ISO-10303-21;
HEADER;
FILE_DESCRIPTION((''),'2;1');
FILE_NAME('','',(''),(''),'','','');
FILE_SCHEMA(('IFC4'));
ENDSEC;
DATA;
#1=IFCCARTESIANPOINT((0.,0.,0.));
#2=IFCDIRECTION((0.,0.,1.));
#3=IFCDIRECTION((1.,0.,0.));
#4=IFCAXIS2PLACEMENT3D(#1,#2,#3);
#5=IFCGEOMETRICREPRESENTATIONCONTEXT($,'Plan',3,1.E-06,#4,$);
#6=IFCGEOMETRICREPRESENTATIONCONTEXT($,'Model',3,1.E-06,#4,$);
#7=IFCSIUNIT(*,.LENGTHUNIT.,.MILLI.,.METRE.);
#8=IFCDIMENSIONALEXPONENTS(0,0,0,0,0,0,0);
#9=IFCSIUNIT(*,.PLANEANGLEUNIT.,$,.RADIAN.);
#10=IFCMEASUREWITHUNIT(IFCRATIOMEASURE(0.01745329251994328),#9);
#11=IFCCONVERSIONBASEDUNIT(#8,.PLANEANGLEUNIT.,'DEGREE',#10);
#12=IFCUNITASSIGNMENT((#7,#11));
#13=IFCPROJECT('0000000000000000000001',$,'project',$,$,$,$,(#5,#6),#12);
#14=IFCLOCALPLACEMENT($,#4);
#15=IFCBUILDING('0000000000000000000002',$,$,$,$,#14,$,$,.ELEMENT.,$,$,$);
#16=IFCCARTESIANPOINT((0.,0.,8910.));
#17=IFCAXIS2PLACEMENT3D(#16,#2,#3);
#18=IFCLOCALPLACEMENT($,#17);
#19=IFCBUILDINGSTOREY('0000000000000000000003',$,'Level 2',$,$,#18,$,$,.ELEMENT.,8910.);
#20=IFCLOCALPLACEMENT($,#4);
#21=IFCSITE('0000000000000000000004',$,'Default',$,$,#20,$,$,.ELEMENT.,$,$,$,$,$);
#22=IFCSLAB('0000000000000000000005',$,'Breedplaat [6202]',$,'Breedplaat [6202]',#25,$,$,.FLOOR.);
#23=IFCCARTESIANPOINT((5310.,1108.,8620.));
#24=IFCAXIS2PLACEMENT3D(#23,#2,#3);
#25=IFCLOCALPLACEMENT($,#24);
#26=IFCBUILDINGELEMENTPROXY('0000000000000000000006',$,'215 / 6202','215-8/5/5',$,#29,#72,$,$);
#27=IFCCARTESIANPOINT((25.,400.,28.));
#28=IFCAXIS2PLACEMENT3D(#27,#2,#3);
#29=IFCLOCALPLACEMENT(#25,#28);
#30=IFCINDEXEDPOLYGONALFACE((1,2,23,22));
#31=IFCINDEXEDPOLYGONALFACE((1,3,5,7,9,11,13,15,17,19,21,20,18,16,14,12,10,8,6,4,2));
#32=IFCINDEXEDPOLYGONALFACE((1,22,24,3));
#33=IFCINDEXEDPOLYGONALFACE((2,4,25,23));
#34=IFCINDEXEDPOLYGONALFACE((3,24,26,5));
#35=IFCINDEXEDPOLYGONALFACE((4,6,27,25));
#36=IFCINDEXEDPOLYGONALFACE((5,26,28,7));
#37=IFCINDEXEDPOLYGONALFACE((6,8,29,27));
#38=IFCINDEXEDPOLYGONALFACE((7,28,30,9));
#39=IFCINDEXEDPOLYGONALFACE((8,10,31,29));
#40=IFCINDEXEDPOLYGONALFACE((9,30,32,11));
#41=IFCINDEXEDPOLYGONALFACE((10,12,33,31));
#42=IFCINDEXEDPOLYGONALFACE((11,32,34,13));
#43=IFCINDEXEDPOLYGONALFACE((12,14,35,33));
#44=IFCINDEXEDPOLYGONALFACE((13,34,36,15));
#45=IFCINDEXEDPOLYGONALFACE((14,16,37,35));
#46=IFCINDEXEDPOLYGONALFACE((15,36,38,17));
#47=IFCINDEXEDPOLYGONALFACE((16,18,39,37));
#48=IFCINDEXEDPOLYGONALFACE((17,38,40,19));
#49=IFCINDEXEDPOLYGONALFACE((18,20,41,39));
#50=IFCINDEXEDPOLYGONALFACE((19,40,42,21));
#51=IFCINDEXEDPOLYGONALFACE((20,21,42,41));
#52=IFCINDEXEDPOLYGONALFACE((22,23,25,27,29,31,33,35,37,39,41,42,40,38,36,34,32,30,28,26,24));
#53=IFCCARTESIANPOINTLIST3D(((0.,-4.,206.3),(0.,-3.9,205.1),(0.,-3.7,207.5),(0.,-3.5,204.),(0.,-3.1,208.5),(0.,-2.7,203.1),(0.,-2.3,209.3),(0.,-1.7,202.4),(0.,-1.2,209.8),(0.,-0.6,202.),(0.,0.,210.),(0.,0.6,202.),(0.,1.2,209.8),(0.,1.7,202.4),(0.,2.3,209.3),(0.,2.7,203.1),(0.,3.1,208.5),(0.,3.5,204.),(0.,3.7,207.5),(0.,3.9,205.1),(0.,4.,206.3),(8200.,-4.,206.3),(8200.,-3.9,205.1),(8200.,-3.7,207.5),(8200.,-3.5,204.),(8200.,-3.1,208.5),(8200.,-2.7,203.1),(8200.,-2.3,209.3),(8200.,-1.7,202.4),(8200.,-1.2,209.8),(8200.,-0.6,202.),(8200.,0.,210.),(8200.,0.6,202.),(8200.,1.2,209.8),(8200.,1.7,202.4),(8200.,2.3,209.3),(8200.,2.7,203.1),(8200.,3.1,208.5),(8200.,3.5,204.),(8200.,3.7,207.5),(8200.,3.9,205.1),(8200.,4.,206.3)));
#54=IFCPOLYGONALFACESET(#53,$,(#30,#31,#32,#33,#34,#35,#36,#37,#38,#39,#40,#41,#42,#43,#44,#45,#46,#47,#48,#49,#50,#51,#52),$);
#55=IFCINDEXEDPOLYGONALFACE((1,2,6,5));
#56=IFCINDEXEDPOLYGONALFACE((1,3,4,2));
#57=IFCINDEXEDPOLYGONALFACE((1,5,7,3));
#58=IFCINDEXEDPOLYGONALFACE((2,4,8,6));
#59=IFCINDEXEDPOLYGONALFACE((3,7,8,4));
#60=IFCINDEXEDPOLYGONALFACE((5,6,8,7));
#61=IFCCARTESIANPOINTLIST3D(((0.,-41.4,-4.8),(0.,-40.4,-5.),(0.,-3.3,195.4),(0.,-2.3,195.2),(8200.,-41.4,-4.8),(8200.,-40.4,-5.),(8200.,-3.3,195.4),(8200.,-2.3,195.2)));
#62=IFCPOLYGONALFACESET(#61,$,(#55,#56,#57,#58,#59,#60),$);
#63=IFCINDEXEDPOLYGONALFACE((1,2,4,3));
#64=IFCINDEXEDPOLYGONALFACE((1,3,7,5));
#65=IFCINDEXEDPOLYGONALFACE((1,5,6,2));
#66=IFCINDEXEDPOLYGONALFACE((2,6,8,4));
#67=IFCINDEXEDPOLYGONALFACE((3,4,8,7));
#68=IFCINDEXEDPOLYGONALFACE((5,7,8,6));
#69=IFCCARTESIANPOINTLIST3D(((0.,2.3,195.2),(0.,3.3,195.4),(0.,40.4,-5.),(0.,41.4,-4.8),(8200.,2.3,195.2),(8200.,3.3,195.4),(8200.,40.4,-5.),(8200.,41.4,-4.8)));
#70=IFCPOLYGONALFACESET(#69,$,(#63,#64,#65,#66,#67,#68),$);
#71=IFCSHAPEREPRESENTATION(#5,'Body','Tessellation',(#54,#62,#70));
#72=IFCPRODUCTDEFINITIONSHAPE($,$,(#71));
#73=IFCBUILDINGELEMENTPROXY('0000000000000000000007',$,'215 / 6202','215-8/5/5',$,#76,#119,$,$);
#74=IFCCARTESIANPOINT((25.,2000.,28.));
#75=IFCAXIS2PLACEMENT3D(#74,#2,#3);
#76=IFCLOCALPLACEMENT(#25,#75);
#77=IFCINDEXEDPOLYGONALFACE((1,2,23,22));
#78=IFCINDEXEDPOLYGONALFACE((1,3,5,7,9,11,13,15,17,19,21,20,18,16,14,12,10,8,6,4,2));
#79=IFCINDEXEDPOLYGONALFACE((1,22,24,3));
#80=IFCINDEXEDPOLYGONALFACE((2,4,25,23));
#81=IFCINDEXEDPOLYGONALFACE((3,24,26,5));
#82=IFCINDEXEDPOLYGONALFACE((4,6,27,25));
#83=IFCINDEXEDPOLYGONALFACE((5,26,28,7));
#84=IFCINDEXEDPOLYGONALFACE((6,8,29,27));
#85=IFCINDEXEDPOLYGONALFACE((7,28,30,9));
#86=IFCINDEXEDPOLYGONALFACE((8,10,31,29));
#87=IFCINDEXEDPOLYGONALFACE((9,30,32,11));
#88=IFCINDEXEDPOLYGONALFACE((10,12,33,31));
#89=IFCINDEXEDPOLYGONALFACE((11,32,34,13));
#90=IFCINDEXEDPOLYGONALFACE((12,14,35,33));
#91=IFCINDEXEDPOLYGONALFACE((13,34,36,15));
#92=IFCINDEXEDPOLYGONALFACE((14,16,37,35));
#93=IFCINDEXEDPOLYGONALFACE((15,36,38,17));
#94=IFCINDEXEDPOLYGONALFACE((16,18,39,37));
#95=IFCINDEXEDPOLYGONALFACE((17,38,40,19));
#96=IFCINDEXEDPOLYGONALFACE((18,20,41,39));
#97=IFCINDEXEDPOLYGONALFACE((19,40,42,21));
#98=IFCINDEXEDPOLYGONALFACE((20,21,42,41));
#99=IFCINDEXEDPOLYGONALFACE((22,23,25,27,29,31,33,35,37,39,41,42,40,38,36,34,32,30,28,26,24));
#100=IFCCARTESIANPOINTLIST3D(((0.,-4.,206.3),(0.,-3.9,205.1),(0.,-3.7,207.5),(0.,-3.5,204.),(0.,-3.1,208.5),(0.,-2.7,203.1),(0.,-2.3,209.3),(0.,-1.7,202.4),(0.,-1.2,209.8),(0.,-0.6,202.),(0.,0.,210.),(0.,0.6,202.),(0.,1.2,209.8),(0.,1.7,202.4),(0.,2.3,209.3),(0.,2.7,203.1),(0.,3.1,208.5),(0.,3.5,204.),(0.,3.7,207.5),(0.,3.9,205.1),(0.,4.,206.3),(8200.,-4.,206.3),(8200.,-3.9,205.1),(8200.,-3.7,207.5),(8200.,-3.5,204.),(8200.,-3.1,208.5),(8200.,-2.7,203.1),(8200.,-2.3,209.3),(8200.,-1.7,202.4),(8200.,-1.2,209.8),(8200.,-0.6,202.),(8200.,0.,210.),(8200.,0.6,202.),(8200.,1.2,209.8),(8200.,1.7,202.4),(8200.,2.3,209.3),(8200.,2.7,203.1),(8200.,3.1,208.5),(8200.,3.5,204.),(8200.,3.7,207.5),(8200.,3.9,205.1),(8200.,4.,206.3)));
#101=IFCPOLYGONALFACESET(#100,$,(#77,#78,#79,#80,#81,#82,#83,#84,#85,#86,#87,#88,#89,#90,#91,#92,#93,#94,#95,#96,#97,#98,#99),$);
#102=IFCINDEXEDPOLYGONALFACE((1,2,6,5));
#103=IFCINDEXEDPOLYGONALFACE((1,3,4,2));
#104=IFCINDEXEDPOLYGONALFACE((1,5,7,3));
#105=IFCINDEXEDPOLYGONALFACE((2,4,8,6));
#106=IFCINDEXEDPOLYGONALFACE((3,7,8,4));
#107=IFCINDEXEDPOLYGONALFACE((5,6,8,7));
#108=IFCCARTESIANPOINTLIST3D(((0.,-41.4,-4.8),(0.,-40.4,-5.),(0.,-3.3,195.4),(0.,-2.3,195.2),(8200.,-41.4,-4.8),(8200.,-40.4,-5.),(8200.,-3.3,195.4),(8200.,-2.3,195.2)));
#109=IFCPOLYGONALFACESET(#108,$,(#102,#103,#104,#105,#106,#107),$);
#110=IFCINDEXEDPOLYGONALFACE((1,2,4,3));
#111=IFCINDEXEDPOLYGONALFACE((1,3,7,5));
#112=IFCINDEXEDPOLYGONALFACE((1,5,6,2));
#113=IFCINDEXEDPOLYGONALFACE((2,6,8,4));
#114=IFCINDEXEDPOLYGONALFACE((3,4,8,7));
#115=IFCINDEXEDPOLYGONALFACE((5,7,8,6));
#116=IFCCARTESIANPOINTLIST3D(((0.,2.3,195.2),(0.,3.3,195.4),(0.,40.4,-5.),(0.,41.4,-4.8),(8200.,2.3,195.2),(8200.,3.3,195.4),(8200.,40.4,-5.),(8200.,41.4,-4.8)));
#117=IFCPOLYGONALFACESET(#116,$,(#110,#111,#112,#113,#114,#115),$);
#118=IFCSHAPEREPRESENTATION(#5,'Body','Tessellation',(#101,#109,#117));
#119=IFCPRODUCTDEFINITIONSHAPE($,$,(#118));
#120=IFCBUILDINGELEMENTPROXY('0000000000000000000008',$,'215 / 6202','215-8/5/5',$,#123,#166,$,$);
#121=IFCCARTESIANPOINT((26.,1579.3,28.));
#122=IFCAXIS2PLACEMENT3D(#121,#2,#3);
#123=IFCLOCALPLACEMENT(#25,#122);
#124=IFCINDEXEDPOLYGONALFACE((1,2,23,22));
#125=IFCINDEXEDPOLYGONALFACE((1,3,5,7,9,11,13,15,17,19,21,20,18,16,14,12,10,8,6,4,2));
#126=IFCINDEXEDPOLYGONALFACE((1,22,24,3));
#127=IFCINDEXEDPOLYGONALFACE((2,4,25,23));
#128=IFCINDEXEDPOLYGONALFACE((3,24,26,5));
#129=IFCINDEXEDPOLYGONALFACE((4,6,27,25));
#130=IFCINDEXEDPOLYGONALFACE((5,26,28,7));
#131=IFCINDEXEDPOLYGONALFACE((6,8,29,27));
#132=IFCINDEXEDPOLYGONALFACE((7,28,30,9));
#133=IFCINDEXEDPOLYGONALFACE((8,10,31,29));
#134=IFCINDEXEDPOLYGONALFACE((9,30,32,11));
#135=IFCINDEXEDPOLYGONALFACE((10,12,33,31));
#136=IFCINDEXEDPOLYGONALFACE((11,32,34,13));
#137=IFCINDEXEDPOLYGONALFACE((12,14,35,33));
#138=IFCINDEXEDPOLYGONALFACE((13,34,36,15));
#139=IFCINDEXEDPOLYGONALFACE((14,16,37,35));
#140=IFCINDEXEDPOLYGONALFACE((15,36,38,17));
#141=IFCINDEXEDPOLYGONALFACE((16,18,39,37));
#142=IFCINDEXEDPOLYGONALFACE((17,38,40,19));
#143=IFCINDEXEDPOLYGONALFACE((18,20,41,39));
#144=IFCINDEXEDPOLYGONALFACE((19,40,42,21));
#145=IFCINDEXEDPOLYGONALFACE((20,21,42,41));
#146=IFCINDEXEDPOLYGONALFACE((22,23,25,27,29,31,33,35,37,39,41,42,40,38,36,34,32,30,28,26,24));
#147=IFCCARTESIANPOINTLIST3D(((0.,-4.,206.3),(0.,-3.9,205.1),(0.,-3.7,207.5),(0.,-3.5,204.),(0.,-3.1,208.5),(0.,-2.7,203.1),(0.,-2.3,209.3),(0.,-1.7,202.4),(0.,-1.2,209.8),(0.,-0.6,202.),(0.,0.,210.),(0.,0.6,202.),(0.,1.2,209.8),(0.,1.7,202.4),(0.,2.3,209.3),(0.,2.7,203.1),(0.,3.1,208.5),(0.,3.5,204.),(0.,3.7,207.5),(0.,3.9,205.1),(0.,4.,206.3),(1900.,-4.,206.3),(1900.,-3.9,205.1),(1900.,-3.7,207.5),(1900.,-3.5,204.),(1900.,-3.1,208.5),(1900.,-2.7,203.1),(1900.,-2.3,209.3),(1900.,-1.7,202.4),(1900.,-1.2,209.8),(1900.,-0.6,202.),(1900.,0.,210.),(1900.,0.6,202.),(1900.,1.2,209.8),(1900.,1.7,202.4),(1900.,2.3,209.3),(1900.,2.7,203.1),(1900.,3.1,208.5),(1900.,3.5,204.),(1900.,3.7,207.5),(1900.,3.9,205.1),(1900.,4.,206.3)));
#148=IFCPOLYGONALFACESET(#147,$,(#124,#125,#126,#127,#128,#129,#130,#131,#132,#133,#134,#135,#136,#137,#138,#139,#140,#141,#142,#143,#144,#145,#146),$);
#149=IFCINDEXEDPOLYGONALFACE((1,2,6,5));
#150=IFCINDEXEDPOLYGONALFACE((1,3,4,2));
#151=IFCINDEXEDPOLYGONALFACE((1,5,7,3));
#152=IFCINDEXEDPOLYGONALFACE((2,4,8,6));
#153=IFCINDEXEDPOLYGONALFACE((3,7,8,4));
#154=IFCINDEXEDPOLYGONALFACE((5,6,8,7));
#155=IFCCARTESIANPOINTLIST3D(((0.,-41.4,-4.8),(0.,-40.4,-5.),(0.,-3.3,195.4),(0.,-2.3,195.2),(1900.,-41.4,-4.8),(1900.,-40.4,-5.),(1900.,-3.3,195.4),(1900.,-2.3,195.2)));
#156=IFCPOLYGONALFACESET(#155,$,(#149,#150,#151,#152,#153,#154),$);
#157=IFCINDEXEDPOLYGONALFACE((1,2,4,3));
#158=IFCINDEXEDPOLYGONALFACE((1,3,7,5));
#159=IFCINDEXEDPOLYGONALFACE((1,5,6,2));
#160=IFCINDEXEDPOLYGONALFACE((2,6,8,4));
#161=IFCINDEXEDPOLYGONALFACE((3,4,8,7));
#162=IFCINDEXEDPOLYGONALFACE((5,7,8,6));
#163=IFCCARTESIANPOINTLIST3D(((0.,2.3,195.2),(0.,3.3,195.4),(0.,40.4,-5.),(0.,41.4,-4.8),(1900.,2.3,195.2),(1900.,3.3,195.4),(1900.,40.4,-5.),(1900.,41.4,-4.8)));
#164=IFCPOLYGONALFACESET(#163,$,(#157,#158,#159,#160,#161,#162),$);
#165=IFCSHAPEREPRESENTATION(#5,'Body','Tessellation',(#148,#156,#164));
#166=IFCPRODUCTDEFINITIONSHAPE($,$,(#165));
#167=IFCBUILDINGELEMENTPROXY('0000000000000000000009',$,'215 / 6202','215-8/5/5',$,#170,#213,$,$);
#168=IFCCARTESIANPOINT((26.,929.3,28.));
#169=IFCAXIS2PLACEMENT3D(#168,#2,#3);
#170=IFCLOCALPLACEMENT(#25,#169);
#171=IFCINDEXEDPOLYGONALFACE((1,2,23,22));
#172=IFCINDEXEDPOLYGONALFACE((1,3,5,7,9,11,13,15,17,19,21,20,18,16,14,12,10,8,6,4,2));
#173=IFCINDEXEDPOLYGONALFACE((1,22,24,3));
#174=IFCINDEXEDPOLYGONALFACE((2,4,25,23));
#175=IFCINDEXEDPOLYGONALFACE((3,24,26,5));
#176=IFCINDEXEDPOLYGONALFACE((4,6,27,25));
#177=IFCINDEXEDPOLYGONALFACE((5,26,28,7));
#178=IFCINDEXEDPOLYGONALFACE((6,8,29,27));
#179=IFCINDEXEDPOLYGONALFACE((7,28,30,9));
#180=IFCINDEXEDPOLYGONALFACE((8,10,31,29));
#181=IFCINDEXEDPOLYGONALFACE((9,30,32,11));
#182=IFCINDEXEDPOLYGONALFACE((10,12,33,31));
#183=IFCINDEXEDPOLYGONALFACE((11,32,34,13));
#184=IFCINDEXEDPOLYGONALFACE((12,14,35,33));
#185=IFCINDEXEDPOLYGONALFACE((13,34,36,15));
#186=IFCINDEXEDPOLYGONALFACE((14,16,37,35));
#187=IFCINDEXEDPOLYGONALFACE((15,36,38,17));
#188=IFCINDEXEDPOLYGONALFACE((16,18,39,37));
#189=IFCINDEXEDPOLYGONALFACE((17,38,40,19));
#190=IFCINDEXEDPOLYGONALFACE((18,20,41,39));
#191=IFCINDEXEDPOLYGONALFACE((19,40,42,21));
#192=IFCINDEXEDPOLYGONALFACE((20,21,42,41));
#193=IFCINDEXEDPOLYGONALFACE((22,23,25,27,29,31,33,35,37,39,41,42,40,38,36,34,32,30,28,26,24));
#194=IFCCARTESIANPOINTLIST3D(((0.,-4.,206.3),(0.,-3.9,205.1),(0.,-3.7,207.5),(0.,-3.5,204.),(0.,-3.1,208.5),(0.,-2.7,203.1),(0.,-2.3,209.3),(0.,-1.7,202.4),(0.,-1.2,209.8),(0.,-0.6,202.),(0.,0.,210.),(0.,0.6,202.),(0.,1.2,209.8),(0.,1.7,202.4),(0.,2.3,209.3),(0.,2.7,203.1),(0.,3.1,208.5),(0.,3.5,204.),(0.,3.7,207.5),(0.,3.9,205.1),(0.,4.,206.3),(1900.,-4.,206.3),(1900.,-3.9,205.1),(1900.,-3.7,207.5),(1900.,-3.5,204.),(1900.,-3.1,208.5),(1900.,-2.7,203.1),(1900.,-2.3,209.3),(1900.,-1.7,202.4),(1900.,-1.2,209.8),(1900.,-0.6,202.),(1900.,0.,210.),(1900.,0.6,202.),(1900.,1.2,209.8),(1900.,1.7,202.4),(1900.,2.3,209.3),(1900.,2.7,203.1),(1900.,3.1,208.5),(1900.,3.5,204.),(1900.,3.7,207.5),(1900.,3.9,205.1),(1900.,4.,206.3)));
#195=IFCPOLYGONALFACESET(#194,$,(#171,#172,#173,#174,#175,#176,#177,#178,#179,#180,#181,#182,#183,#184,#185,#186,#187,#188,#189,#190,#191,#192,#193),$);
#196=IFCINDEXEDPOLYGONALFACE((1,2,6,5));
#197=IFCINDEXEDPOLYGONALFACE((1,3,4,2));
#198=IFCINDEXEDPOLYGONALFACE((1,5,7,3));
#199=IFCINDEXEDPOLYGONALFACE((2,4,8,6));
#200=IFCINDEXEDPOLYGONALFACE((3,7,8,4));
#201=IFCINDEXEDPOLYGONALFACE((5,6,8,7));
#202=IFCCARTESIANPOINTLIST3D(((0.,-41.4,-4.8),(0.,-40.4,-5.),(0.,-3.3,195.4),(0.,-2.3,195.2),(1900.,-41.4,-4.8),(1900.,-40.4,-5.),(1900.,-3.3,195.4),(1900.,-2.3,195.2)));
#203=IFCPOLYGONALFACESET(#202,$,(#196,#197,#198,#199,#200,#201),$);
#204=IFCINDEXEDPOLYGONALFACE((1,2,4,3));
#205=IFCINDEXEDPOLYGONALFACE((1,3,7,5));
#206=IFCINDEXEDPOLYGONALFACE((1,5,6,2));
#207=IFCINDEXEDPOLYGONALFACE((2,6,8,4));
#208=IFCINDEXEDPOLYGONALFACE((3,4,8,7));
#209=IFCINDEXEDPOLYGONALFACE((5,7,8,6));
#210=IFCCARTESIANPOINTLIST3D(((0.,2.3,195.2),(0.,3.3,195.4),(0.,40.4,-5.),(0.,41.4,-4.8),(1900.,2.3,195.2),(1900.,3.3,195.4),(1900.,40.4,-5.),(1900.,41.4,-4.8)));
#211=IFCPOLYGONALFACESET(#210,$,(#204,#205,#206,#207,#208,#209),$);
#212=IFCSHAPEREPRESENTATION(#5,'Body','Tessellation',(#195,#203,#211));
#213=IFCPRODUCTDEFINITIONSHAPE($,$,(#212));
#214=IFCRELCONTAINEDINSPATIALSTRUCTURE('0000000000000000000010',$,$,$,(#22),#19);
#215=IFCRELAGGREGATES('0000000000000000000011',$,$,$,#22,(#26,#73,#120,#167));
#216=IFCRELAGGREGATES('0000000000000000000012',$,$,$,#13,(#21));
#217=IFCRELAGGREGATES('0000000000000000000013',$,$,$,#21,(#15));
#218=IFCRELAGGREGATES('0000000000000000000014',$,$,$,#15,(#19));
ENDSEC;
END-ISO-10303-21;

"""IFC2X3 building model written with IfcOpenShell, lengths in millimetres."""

from ifc_helpers import new_model, entity, si_unit, converted_unit, frame, origin_with_axes, origin_2d_with_axis, place, context, project, spatial, rectangle, circle, extrude, element, aggregate, save


model = new_model("IFC2X3")

# Units and contexts
plan_context = context("Plan", 3, precision=1e-06, world=origin_with_axes())
model_context = context("Model", 3, precision=1e-06, world=origin_with_axes())
ifc_project = project(units=[si_unit("LENGTHUNIT", "METRE", prefix="MILLI"), converted_unit("PLANEANGLEUNIT", "DEGREE", entity("IfcRatioMeasure", 0.01745329251994328), si_unit("PLANEANGLEUNIT", "RADIAN"), dimensions=[0, 0, 0, 0, 0, 0, 0])], contexts=[plan_context, model_context])

# Site, building, storey
site_placement = place(None, origin_with_axes())
site = spatial("IfcSite", under=ifc_project, at=site_placement, Name="Default", CompositionType="ELEMENT")
building_placement = place(None, origin_with_axes())
building = spatial("IfcBuilding", under=site, at=building_placement, CompositionType="ELEMENT")
storey_placement = place(None, frame((0.0, 0.0, 8910.0), z_axis=(0.0, 0.0, 1.0), x_axis=(1.0, 0.0, 0.0)))
storey = spatial("IfcBuildingStorey", under=building, at=storey_placement, Name="Level 2", CompositionType="ELEMENT", Elevation=8910.0)

# Slab, building element proxies
slab_1_placement = place(None, frame((5310.0, 1108.0, 8620.0), z_axis=(0.0, 0.0, 1.0), x_axis=(1.0, 0.0, 0.0)))
slab_1 = element("IfcSlab", 1, at=slab_1_placement, inside=storey, Name="Breedplaat [6202]", ObjectType="Breedplaat [6202]", PredefinedType="FLOOR")
proxy_1_placement = place(slab_1_placement, frame((25.0, 400.0, 28.0), z_axis=(0.0, 0.0, 1.0), x_axis=(1.0, 0.0, 0.0)))
proxy_1 = element("IfcBuildingElementProxy", 2, at=proxy_1_placement, Name="215 / 6202", Description="215-8/5/5", context=plan_context, shape_type="SweptSolid", body=[
    extrude(circle(Radius=4.0, at=origin_2d_with_axis()), frame((0.0, 0.0, 206.0), z_axis=(1.0, 0.0, 0.0), x_axis=(0.0, 0.0, 1.0)), (0.0, 0.0, 1.0), 8200.0),
    extrude(rectangle(XDim=203.8, YDim=1.0, at=origin_2d_with_axis()), frame((0.0, -21.9, 95.2), z_axis=(1.0, 0.0, 0.0), x_axis=(0.0, 0.187112, 0.982339)), (0.0, 0.0, 1.0), 8200.0),
    extrude(rectangle(XDim=203.8, YDim=1.0, at=origin_2d_with_axis()), frame((0.0, 21.9, 95.2), z_axis=(1.0, 0.0, 0.0), x_axis=(0.0, -0.187112, 0.982339)), (0.0, 0.0, 1.0), 8200.0),
])
proxy_2_placement = place(slab_1_placement, frame((25.0, 2000.0, 28.0), z_axis=(0.0, 0.0, 1.0), x_axis=(1.0, 0.0, 0.0)))
proxy_2 = element("IfcBuildingElementProxy", 3, at=proxy_2_placement, Name="215 / 6202", Description="215-8/5/5", context=plan_context, shape_type="SweptSolid", body=[
    extrude(circle(Radius=4.0, at=origin_2d_with_axis()), frame((0.0, 0.0, 206.0), z_axis=(1.0, 0.0, 0.0), x_axis=(0.0, 0.0, 1.0)), (0.0, 0.0, 1.0), 8200.0),
    extrude(rectangle(XDim=203.8, YDim=1.0, at=origin_2d_with_axis()), frame((0.0, -21.9, 95.2), z_axis=(1.0, 0.0, 0.0), x_axis=(0.0, 0.187112, 0.982339)), (0.0, 0.0, 1.0), 8200.0),
    extrude(rectangle(XDim=203.8, YDim=1.0, at=origin_2d_with_axis()), frame((0.0, 21.9, 95.2), z_axis=(1.0, 0.0, 0.0), x_axis=(0.0, -0.187112, 0.982339)), (0.0, 0.0, 1.0), 8200.0),
])
proxy_3_placement = place(slab_1_placement, frame((26.0, 1579.3, 28.0), z_axis=(0.0, 0.0, 1.0), x_axis=(1.0, 0.0, 0.0)))
proxy_3 = element("IfcBuildingElementProxy", 4, at=proxy_3_placement, Name="215 / 6202", Description="215-8/5/5", context=plan_context, shape_type="SweptSolid", body=[
    extrude(circle(Radius=4.0, at=origin_2d_with_axis()), frame((0.0, 0.0, 206.0), z_axis=(1.0, 0.0, 0.0), x_axis=(0.0, 0.0, 1.0)), (0.0, 0.0, 1.0), 1900.0),
    extrude(rectangle(XDim=203.8, YDim=1.0, at=origin_2d_with_axis()), frame((0.0, -21.9, 95.2), z_axis=(1.0, 0.0, 0.0), x_axis=(0.0, 0.187112, 0.982339)), (0.0, 0.0, 1.0), 1900.0),
    extrude(rectangle(XDim=203.8, YDim=1.0, at=origin_2d_with_axis()), frame((0.0, 21.9, 95.2), z_axis=(1.0, 0.0, 0.0), x_axis=(0.0, -0.187112, 0.982339)), (0.0, 0.0, 1.0), 1900.0),
])
proxy_4_placement = place(slab_1_placement, frame((26.0, 929.3, 28.0), z_axis=(0.0, 0.0, 1.0), x_axis=(1.0, 0.0, 0.0)))
proxy_4 = element("IfcBuildingElementProxy", 5, at=proxy_4_placement, Name="215 / 6202", Description="215-8/5/5", context=plan_context, shape_type="SweptSolid", body=[
    extrude(circle(Radius=4.0, at=origin_2d_with_axis()), frame((0.0, 0.0, 206.0), z_axis=(1.0, 0.0, 0.0), x_axis=(0.0, 0.0, 1.0)), (0.0, 0.0, 1.0), 1900.0),
    extrude(rectangle(XDim=203.8, YDim=1.0, at=origin_2d_with_axis()), frame((0.0, -21.9, 95.2), z_axis=(1.0, 0.0, 0.0), x_axis=(0.0, 0.187112, 0.982339)), (0.0, 0.0, 1.0), 1900.0),
    extrude(rectangle(XDim=203.8, YDim=1.0, at=origin_2d_with_axis()), frame((0.0, 21.9, 95.2), z_axis=(1.0, 0.0, 0.0), x_axis=(0.0, -0.187112, 0.982339)), (0.0, 0.0, 1.0), 1900.0),
])
aggregate(slab_1, [proxy_1, proxy_2, proxy_3, proxy_4])

save(model, "model.ifc")
